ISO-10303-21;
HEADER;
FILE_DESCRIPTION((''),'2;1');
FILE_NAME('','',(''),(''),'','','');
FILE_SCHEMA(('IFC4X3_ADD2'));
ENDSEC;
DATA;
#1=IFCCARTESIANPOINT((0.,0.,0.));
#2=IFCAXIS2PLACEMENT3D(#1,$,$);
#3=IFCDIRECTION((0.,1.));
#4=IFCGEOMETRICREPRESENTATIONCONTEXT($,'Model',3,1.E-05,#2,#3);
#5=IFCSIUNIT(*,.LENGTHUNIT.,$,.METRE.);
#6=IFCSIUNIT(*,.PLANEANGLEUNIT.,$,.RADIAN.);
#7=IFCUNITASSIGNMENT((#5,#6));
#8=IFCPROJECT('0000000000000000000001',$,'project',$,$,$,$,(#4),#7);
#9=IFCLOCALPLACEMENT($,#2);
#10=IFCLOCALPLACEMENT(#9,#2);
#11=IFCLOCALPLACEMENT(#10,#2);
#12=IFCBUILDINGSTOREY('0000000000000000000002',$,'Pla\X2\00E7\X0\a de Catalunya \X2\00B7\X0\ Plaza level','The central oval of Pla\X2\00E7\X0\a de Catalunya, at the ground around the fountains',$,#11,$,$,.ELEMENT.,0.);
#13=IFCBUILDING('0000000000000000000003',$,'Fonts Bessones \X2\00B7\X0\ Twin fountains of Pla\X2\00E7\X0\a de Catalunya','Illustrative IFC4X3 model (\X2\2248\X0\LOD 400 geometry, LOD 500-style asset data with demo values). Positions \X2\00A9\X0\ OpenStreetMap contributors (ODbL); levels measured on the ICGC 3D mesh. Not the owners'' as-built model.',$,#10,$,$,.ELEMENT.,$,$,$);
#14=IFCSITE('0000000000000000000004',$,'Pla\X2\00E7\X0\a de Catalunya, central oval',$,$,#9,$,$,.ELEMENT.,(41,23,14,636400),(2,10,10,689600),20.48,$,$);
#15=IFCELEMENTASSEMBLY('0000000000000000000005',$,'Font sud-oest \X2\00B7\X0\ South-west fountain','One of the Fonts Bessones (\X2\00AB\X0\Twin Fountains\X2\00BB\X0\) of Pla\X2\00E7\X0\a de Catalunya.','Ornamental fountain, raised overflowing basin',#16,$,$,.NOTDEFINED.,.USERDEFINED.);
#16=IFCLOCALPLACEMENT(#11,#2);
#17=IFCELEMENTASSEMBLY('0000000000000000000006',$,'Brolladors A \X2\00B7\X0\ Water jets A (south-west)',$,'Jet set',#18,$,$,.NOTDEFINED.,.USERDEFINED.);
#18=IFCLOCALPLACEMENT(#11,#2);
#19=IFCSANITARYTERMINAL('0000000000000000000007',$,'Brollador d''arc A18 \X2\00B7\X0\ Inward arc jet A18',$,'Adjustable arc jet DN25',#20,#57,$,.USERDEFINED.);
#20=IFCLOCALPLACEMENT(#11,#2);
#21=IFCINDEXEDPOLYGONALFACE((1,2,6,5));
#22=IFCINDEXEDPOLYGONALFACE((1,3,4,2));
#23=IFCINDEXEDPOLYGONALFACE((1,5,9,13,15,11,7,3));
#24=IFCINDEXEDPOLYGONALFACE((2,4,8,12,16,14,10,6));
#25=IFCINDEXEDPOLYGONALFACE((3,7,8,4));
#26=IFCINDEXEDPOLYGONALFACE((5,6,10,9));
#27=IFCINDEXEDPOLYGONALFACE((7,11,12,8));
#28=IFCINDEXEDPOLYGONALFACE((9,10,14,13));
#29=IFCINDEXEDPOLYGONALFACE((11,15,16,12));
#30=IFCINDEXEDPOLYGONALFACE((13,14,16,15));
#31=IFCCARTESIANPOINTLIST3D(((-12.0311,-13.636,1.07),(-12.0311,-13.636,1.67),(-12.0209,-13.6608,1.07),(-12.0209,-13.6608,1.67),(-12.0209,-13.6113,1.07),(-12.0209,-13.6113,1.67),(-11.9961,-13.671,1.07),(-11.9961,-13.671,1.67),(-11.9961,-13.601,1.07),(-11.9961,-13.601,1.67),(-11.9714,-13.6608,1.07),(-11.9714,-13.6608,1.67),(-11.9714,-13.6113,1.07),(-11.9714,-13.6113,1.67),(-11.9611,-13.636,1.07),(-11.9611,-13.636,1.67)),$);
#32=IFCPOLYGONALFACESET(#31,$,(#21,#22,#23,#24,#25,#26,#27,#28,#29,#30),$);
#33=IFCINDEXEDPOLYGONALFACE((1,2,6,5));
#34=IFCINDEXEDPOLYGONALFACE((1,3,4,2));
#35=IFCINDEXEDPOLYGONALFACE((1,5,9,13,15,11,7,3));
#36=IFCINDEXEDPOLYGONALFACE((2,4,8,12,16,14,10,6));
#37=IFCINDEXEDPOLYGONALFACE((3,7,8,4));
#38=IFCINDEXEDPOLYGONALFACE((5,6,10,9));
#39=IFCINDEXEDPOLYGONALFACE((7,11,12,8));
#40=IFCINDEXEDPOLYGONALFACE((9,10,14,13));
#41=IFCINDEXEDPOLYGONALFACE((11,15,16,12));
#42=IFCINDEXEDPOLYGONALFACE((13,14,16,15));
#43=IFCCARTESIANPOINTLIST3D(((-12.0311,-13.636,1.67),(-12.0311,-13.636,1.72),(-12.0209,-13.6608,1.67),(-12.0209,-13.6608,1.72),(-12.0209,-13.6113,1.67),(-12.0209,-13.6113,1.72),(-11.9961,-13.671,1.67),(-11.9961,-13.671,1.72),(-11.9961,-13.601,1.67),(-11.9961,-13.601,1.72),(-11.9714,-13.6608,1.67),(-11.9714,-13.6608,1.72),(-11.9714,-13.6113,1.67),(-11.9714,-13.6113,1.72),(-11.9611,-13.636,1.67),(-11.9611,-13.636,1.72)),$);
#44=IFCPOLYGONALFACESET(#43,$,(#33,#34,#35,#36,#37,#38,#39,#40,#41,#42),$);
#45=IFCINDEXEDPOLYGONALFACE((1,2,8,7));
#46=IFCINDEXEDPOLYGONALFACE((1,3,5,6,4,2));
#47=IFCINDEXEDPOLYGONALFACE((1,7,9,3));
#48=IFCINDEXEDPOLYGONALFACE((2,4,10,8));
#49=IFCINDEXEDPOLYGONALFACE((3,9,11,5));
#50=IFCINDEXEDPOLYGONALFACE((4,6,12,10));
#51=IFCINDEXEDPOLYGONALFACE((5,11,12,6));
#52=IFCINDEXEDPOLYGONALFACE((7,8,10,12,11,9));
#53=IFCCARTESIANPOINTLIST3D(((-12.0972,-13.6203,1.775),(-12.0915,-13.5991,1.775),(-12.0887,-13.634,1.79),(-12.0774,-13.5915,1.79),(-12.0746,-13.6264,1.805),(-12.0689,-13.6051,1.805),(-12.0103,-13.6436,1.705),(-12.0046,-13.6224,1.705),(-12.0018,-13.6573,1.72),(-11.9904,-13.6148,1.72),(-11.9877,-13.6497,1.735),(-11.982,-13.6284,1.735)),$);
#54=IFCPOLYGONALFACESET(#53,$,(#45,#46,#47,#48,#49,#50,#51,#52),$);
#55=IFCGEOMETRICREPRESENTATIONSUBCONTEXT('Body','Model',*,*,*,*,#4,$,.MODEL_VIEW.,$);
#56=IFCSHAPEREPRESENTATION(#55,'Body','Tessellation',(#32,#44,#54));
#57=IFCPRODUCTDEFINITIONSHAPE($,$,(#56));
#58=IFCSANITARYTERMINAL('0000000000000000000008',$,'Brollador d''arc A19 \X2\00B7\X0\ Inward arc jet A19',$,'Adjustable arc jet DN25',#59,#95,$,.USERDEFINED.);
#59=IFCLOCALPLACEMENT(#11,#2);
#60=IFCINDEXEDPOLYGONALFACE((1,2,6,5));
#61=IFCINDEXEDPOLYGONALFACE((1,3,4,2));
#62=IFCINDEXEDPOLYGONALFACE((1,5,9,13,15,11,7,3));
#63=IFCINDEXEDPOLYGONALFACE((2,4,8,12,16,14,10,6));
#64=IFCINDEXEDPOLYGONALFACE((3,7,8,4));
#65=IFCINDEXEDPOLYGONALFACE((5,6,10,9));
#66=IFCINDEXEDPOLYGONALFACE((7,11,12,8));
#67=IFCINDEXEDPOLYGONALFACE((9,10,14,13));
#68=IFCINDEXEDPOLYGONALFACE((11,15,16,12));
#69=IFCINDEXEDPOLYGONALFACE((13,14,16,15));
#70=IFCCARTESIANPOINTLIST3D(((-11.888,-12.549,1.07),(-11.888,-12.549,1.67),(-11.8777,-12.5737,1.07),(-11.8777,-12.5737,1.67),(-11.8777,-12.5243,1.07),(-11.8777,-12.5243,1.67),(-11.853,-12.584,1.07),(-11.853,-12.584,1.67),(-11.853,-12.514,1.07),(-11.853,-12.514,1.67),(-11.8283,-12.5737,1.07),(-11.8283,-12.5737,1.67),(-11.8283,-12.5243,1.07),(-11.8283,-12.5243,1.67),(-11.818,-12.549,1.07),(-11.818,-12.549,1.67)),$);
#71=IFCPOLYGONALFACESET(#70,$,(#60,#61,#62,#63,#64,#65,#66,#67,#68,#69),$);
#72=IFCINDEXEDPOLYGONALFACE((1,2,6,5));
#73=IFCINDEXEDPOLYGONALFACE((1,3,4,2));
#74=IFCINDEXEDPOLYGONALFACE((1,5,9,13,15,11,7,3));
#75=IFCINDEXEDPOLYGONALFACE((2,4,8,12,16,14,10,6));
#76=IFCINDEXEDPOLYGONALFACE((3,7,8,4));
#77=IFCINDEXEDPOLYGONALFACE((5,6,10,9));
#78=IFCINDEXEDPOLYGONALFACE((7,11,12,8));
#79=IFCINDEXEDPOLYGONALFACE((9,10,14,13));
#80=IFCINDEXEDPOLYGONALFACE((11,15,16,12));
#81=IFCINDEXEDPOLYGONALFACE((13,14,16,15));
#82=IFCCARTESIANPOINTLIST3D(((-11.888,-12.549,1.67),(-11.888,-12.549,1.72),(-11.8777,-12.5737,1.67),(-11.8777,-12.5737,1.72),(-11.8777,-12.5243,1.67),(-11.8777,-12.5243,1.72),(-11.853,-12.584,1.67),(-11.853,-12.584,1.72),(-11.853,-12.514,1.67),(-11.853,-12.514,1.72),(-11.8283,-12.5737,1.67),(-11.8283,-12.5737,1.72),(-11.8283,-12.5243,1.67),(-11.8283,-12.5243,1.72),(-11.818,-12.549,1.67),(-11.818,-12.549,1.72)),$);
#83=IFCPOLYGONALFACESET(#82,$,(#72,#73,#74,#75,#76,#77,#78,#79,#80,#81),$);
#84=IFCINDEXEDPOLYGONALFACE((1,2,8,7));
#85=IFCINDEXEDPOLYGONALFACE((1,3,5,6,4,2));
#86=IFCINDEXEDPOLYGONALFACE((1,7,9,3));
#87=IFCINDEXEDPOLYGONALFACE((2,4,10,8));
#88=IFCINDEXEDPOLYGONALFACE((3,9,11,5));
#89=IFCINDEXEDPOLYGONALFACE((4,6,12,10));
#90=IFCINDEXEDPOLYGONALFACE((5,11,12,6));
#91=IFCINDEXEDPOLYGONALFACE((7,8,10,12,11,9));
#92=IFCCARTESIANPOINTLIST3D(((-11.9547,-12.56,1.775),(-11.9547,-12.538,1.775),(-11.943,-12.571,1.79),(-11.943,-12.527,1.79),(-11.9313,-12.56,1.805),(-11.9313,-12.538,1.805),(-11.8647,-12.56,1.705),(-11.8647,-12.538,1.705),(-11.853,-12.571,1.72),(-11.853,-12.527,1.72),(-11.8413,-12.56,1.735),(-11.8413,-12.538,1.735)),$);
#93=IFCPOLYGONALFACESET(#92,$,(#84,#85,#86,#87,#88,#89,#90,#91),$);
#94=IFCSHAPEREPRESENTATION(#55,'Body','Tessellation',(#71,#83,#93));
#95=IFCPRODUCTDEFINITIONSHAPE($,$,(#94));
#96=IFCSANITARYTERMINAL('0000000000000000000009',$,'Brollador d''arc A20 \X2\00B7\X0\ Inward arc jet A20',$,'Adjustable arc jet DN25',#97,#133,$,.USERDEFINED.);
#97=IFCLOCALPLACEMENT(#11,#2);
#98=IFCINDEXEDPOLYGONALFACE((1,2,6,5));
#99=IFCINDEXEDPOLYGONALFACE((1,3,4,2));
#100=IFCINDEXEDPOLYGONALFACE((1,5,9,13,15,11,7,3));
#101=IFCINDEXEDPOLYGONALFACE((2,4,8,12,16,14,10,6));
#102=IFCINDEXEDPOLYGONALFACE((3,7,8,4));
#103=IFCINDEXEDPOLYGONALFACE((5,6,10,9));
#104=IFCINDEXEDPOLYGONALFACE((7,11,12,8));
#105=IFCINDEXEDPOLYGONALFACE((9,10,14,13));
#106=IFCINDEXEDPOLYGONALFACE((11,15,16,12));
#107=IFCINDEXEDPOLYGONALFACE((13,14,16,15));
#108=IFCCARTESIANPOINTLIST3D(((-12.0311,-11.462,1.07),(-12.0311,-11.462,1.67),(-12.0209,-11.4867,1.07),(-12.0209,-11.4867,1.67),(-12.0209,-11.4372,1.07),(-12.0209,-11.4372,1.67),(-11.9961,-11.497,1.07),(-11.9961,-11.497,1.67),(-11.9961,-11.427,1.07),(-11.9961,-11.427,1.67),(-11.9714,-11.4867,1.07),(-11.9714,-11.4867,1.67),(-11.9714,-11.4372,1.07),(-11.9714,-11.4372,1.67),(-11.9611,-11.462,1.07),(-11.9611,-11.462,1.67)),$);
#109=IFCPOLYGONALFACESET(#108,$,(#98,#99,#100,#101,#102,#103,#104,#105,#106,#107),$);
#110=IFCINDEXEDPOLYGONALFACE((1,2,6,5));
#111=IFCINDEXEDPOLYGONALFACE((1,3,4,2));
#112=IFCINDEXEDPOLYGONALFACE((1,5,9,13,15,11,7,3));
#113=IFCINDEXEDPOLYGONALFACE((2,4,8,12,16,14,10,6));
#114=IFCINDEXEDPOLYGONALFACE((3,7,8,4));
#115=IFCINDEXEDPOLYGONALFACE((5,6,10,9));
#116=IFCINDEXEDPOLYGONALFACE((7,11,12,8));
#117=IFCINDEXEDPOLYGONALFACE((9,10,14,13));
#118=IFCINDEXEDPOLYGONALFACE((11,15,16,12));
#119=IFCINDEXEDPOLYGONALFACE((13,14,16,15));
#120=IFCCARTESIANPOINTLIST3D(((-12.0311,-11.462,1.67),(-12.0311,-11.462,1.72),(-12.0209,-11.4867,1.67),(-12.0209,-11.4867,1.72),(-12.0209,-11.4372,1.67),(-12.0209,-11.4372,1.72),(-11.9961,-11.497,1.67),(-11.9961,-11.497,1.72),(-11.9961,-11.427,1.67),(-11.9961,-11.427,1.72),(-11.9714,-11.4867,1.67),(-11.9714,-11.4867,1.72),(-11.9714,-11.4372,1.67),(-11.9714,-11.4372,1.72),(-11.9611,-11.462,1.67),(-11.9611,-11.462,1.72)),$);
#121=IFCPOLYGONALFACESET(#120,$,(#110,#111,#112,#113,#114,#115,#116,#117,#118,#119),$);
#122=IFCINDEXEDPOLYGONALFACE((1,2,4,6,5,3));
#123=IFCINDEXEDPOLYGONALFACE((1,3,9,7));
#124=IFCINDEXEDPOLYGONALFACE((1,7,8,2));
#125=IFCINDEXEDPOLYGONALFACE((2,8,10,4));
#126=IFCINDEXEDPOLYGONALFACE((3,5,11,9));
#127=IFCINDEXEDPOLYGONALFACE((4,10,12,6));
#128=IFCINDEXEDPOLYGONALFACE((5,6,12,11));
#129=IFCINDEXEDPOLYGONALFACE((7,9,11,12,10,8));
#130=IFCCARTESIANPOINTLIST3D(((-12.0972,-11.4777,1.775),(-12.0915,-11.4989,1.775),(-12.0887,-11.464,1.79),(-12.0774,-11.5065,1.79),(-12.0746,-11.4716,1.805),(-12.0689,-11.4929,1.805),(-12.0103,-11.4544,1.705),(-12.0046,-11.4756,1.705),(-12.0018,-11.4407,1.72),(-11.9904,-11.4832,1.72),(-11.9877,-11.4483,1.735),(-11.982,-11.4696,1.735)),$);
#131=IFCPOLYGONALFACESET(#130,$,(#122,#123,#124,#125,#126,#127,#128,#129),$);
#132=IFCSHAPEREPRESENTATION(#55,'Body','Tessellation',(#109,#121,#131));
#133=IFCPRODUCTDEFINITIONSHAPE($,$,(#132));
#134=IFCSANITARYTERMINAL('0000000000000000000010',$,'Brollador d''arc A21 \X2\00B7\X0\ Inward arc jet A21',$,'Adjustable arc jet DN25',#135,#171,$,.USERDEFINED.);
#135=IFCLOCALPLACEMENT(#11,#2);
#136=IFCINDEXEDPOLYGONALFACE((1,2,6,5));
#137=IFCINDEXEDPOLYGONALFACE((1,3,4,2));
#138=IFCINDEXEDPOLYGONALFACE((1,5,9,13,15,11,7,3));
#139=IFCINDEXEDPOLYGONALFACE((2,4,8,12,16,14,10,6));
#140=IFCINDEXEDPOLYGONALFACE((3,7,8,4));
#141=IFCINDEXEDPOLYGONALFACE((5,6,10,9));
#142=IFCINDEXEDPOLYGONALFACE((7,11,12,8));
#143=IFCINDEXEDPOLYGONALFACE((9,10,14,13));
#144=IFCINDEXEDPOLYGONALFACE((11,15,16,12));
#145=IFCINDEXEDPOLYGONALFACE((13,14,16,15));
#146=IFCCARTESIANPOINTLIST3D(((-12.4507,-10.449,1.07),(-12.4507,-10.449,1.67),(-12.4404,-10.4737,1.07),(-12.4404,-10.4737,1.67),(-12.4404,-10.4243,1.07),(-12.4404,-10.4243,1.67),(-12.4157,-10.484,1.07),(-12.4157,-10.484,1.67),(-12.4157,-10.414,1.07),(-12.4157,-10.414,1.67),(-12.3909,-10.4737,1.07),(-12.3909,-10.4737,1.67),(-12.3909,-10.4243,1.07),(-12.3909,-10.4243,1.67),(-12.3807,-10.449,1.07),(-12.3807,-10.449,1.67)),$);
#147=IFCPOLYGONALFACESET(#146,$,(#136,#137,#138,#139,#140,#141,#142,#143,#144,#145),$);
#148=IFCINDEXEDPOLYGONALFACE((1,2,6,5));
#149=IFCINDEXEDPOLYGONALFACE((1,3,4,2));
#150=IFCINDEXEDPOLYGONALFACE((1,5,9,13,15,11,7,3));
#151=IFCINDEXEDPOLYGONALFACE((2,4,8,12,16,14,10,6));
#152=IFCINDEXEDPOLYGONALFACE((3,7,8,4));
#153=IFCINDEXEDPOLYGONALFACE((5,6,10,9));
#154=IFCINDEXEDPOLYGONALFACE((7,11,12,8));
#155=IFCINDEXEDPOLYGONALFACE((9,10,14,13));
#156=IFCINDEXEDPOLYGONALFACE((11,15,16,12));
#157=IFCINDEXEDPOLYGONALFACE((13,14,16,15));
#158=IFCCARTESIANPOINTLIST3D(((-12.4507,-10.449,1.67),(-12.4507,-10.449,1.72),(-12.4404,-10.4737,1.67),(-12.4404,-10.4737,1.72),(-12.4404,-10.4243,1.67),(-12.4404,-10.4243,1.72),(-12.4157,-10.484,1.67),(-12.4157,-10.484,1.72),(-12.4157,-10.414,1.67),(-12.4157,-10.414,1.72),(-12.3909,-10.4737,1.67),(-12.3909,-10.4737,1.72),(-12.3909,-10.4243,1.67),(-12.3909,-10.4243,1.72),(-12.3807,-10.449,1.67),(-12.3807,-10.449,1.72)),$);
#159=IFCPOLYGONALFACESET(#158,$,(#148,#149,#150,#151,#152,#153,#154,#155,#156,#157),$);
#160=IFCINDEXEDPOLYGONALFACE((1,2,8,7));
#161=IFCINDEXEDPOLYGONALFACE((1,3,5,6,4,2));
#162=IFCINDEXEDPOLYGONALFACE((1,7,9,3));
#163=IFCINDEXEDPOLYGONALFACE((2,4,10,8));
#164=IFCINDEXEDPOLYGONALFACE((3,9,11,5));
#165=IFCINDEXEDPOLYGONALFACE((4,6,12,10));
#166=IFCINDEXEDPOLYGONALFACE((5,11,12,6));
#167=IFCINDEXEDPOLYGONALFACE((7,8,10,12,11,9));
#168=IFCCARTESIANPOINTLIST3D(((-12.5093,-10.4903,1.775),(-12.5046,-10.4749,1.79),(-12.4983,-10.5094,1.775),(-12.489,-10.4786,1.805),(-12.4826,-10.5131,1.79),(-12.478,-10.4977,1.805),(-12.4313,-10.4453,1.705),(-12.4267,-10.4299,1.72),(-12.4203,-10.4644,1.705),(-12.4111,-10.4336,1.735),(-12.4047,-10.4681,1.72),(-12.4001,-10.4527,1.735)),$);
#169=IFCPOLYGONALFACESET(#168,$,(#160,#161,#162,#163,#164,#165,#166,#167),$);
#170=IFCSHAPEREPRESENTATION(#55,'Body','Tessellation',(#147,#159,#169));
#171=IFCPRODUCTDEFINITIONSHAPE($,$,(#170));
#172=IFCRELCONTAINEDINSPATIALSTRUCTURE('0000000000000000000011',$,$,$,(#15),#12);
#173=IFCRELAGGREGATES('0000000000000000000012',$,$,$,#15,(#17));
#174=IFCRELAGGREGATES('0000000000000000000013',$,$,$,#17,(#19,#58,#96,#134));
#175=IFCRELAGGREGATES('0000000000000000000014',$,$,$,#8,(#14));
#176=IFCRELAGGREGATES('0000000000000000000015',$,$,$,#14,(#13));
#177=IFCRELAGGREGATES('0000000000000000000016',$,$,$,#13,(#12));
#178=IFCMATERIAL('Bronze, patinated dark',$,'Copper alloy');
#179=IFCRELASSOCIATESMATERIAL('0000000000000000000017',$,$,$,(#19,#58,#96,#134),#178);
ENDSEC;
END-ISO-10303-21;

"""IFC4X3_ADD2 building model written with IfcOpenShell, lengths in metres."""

from ifc_helpers import new_model, si_unit, direction, frame, origin, place, context, subcontext, project, spatial, polyline, outline, extrude, material, element, aggregate, save


model = new_model("IFC4X3_ADD2")

# Units and contexts
model_context = context("Model", 3, precision=1e-05, world=origin(), true_north=direction((0.0, 1.0)))
body_context = subcontext(model_context, "Body", "Model", "MODEL_VIEW")
ifc_project = project(units=[si_unit("LENGTHUNIT", "METRE"), si_unit("PLANEANGLEUNIT", "RADIAN")], contexts=[model_context])

# Site, building, storey
site_placement = place(None, origin())
site = spatial("IfcSite", under=ifc_project, at=site_placement, Name="Plaça de Catalunya, central oval", CompositionType="ELEMENT", RefLatitude=(41, 23, 14, 636400), RefLongitude=(2, 10, 10, 689600), RefElevation=20.48)
building_placement = place(site_placement, origin())
building = spatial("IfcBuilding", under=site, at=building_placement, Name="Fonts Bessones · Twin fountains of Plaça de Catalunya", Description="Illustrative IFC4X3 model (≈LOD 400 geometry, LOD 500-style asset data with demo values). Positions © OpenStreetMap contributors (ODbL); levels measured on the ICGC 3D mesh. Not the owners' as-built model.", CompositionType="ELEMENT")
storey_placement = place(building_placement, origin())
storey = spatial("IfcBuildingStorey", under=building, at=storey_placement, Name="Plaça de Catalunya · Plaza level", Description="The central oval of Plaça de Catalunya, at the ground around the fountains", CompositionType="ELEMENT", Elevation=0.0)

# Element assemblies, sanitary terminals
assembly_1_placement = place(building_placement, origin())
assembly_1 = element("IfcElementAssembly", 1, at=assembly_1_placement, inside=storey, Name="Font sud-oest · South-west fountain", Description="One of the Fonts Bessones («Twin Fountains») of Plaça de Catalunya.", ObjectType="Ornamental fountain, raised overflowing basin", AssemblyPlace="NOTDEFINED", PredefinedType="USERDEFINED")
assembly_2_placement = place(building_placement, origin())
assembly_2 = element("IfcElementAssembly", 2, at=assembly_2_placement, Name="Brolladors A · Water jets A (south-west)", ObjectType="Jet set", AssemblyPlace="NOTDEFINED", PredefinedType="USERDEFINED")
aggregate(assembly_1, [assembly_2])
ifc_material = material(Name="Bronze, patinated dark", Category="Copper alloy")
sanitary_terminal_1_placement = place(building_placement, origin())
sanitary_terminal_1 = element("IfcSanitaryTerminal", 3, at=sanitary_terminal_1_placement, material=ifc_material, Name="Brollador d'arc A18 · Inward arc jet A18", ObjectType="Adjustable arc jet DN25", PredefinedType="USERDEFINED", context=body_context, shape_type="SweptSolid", body=[
    extrude(outline(polyline([(-11.9611, -13.636), (-11.9714, -13.6113), (-11.9961, -13.601), (-12.0209, -13.6113), (-12.0311, -13.636), (-12.0209, -13.6608), (-11.9961, -13.671), (-11.9714, -13.6608), (-11.9611, -13.636)])), frame((0.0, 0.0, 1.07)), (0.0, 0.0, 1.0), 0.6),
    extrude(outline(polyline([(-11.9611, -13.636), (-11.9714, -13.6113), (-11.9961, -13.601), (-12.0209, -13.6113), (-12.0311, -13.636), (-12.0209, -13.6608), (-11.9961, -13.671), (-11.9714, -13.6608), (-11.9611, -13.636)])), frame((0.0, 0.0, 1.67)), (0.0, 0.0, 1.0), 0.05),
    extrude(outline(polyline([(0.022, 0.0), (0.011, 0.0191), (-0.011, 0.0191), (-0.022, 0.0), (-0.011, -0.0191), (0.011, -0.0191), (0.022, 0.0)])), frame((-11.9961, -13.636, 1.72), z_axis=(-0.762456, 0.204299, 0.613941), x_axis=(0.258819, 0.965926, 0.0)), (0.0, 0.0, 1.0), 0.114),
])
sanitary_terminal_2_placement = place(building_placement, origin())
sanitary_terminal_2 = element("IfcSanitaryTerminal", 4, at=sanitary_terminal_2_placement, material=ifc_material, Name="Brollador d'arc A19 · Inward arc jet A19", ObjectType="Adjustable arc jet DN25", PredefinedType="USERDEFINED", context=body_context, shape_type="SweptSolid", body=[
    extrude(outline(polyline([(-11.818, -12.549), (-11.8283, -12.5243), (-11.853, -12.514), (-11.8777, -12.5243), (-11.888, -12.549), (-11.8777, -12.5737), (-11.853, -12.584), (-11.8283, -12.5737), (-11.818, -12.549)])), frame((0.0, 0.0, 1.07)), (0.0, 0.0, 1.0), 0.6),
    extrude(outline(polyline([(-11.818, -12.549), (-11.8283, -12.5243), (-11.853, -12.514), (-11.8777, -12.5243), (-11.888, -12.549), (-11.8777, -12.5737), (-11.853, -12.584), (-11.8283, -12.5737), (-11.818, -12.549)])), frame((0.0, 0.0, 1.67)), (0.0, 0.0, 1.0), 0.05),
    extrude(outline(polyline([(0.022, 0.0), (0.011, 0.0191), (-0.011, 0.0191), (-0.022, 0.0), (-0.011, -0.0191), (0.011, -0.0191), (0.022, 0.0)])), frame((-11.853, -12.549, 1.72), z_axis=(-0.789352, 0.0, 0.613941), x_axis=(0.0, 1.0, 0.0)), (0.0, 0.0, 1.0), 0.114),
])
sanitary_terminal_3_placement = place(building_placement, origin())
sanitary_terminal_3 = element("IfcSanitaryTerminal", 5, at=sanitary_terminal_3_placement, material=ifc_material, Name="Brollador d'arc A20 · Inward arc jet A20", ObjectType="Adjustable arc jet DN25", PredefinedType="USERDEFINED", context=body_context, shape_type="SweptSolid", body=[
    extrude(outline(polyline([(-11.9611, -11.462), (-11.9714, -11.4372), (-11.9961, -11.427), (-12.0209, -11.4372), (-12.0311, -11.462), (-12.0209, -11.4867), (-11.9961, -11.497), (-11.9714, -11.4867), (-11.9611, -11.462)])), frame((0.0, 0.0, 1.07)), (0.0, 0.0, 1.0), 0.6),
    extrude(outline(polyline([(-11.9611, -11.462), (-11.9714, -11.4372), (-11.9961, -11.427), (-12.0209, -11.4372), (-12.0311, -11.462), (-12.0209, -11.4867), (-11.9961, -11.497), (-11.9714, -11.4867), (-11.9611, -11.462)])), frame((0.0, 0.0, 1.67)), (0.0, 0.0, 1.0), 0.05),
    extrude(outline(polyline([(0.022, 0.0), (0.011, 0.0191), (-0.011, 0.0191), (-0.022, 0.0), (-0.011, -0.0191), (0.011, -0.0191), (0.022, 0.0)])), frame((-11.9961, -11.462, 1.72), z_axis=(-0.762456, -0.204299, 0.613941), x_axis=(-0.258819, 0.965926, 0.0)), (0.0, 0.0, 1.0), 0.114),
])
sanitary_terminal_4_placement = place(building_placement, origin())
sanitary_terminal_4 = element("IfcSanitaryTerminal", 6, at=sanitary_terminal_4_placement, material=ifc_material, Name="Brollador d'arc A21 · Inward arc jet A21", ObjectType="Adjustable arc jet DN25", PredefinedType="USERDEFINED", context=body_context, shape_type="SweptSolid", body=[
    extrude(outline(polyline([(-12.3807, -10.449), (-12.3909, -10.4243), (-12.4157, -10.414), (-12.4404, -10.4243), (-12.4507, -10.449), (-12.4404, -10.4737), (-12.4157, -10.484), (-12.3909, -10.4737), (-12.3807, -10.449)])), frame((0.0, 0.0, 1.07)), (0.0, 0.0, 1.0), 0.6),
    extrude(outline(polyline([(-12.3807, -10.449), (-12.3909, -10.4243), (-12.4157, -10.414), (-12.4404, -10.4243), (-12.4507, -10.449), (-12.4404, -10.4737), (-12.4157, -10.484), (-12.3909, -10.4737), (-12.3807, -10.449)])), frame((0.0, 0.0, 1.67)), (0.0, 0.0, 1.0), 0.05),
    extrude(outline(polyline([(0.022, 0.0), (0.011, 0.0191), (-0.011, 0.0191), (-0.022, 0.0), (-0.011, -0.0191), (0.011, -0.0191), (0.022, 0.0)])), frame((-12.4157, -10.449, 1.72), z_axis=(-0.683599, -0.394676, 0.613941), x_axis=(-0.5, 0.866025, 0.0)), (0.0, 0.0, 1.0), 0.114),
])
aggregate(assembly_2, [sanitary_terminal_1, sanitary_terminal_2, sanitary_terminal_3, sanitary_terminal_4])

save(model, "model.ifc")
